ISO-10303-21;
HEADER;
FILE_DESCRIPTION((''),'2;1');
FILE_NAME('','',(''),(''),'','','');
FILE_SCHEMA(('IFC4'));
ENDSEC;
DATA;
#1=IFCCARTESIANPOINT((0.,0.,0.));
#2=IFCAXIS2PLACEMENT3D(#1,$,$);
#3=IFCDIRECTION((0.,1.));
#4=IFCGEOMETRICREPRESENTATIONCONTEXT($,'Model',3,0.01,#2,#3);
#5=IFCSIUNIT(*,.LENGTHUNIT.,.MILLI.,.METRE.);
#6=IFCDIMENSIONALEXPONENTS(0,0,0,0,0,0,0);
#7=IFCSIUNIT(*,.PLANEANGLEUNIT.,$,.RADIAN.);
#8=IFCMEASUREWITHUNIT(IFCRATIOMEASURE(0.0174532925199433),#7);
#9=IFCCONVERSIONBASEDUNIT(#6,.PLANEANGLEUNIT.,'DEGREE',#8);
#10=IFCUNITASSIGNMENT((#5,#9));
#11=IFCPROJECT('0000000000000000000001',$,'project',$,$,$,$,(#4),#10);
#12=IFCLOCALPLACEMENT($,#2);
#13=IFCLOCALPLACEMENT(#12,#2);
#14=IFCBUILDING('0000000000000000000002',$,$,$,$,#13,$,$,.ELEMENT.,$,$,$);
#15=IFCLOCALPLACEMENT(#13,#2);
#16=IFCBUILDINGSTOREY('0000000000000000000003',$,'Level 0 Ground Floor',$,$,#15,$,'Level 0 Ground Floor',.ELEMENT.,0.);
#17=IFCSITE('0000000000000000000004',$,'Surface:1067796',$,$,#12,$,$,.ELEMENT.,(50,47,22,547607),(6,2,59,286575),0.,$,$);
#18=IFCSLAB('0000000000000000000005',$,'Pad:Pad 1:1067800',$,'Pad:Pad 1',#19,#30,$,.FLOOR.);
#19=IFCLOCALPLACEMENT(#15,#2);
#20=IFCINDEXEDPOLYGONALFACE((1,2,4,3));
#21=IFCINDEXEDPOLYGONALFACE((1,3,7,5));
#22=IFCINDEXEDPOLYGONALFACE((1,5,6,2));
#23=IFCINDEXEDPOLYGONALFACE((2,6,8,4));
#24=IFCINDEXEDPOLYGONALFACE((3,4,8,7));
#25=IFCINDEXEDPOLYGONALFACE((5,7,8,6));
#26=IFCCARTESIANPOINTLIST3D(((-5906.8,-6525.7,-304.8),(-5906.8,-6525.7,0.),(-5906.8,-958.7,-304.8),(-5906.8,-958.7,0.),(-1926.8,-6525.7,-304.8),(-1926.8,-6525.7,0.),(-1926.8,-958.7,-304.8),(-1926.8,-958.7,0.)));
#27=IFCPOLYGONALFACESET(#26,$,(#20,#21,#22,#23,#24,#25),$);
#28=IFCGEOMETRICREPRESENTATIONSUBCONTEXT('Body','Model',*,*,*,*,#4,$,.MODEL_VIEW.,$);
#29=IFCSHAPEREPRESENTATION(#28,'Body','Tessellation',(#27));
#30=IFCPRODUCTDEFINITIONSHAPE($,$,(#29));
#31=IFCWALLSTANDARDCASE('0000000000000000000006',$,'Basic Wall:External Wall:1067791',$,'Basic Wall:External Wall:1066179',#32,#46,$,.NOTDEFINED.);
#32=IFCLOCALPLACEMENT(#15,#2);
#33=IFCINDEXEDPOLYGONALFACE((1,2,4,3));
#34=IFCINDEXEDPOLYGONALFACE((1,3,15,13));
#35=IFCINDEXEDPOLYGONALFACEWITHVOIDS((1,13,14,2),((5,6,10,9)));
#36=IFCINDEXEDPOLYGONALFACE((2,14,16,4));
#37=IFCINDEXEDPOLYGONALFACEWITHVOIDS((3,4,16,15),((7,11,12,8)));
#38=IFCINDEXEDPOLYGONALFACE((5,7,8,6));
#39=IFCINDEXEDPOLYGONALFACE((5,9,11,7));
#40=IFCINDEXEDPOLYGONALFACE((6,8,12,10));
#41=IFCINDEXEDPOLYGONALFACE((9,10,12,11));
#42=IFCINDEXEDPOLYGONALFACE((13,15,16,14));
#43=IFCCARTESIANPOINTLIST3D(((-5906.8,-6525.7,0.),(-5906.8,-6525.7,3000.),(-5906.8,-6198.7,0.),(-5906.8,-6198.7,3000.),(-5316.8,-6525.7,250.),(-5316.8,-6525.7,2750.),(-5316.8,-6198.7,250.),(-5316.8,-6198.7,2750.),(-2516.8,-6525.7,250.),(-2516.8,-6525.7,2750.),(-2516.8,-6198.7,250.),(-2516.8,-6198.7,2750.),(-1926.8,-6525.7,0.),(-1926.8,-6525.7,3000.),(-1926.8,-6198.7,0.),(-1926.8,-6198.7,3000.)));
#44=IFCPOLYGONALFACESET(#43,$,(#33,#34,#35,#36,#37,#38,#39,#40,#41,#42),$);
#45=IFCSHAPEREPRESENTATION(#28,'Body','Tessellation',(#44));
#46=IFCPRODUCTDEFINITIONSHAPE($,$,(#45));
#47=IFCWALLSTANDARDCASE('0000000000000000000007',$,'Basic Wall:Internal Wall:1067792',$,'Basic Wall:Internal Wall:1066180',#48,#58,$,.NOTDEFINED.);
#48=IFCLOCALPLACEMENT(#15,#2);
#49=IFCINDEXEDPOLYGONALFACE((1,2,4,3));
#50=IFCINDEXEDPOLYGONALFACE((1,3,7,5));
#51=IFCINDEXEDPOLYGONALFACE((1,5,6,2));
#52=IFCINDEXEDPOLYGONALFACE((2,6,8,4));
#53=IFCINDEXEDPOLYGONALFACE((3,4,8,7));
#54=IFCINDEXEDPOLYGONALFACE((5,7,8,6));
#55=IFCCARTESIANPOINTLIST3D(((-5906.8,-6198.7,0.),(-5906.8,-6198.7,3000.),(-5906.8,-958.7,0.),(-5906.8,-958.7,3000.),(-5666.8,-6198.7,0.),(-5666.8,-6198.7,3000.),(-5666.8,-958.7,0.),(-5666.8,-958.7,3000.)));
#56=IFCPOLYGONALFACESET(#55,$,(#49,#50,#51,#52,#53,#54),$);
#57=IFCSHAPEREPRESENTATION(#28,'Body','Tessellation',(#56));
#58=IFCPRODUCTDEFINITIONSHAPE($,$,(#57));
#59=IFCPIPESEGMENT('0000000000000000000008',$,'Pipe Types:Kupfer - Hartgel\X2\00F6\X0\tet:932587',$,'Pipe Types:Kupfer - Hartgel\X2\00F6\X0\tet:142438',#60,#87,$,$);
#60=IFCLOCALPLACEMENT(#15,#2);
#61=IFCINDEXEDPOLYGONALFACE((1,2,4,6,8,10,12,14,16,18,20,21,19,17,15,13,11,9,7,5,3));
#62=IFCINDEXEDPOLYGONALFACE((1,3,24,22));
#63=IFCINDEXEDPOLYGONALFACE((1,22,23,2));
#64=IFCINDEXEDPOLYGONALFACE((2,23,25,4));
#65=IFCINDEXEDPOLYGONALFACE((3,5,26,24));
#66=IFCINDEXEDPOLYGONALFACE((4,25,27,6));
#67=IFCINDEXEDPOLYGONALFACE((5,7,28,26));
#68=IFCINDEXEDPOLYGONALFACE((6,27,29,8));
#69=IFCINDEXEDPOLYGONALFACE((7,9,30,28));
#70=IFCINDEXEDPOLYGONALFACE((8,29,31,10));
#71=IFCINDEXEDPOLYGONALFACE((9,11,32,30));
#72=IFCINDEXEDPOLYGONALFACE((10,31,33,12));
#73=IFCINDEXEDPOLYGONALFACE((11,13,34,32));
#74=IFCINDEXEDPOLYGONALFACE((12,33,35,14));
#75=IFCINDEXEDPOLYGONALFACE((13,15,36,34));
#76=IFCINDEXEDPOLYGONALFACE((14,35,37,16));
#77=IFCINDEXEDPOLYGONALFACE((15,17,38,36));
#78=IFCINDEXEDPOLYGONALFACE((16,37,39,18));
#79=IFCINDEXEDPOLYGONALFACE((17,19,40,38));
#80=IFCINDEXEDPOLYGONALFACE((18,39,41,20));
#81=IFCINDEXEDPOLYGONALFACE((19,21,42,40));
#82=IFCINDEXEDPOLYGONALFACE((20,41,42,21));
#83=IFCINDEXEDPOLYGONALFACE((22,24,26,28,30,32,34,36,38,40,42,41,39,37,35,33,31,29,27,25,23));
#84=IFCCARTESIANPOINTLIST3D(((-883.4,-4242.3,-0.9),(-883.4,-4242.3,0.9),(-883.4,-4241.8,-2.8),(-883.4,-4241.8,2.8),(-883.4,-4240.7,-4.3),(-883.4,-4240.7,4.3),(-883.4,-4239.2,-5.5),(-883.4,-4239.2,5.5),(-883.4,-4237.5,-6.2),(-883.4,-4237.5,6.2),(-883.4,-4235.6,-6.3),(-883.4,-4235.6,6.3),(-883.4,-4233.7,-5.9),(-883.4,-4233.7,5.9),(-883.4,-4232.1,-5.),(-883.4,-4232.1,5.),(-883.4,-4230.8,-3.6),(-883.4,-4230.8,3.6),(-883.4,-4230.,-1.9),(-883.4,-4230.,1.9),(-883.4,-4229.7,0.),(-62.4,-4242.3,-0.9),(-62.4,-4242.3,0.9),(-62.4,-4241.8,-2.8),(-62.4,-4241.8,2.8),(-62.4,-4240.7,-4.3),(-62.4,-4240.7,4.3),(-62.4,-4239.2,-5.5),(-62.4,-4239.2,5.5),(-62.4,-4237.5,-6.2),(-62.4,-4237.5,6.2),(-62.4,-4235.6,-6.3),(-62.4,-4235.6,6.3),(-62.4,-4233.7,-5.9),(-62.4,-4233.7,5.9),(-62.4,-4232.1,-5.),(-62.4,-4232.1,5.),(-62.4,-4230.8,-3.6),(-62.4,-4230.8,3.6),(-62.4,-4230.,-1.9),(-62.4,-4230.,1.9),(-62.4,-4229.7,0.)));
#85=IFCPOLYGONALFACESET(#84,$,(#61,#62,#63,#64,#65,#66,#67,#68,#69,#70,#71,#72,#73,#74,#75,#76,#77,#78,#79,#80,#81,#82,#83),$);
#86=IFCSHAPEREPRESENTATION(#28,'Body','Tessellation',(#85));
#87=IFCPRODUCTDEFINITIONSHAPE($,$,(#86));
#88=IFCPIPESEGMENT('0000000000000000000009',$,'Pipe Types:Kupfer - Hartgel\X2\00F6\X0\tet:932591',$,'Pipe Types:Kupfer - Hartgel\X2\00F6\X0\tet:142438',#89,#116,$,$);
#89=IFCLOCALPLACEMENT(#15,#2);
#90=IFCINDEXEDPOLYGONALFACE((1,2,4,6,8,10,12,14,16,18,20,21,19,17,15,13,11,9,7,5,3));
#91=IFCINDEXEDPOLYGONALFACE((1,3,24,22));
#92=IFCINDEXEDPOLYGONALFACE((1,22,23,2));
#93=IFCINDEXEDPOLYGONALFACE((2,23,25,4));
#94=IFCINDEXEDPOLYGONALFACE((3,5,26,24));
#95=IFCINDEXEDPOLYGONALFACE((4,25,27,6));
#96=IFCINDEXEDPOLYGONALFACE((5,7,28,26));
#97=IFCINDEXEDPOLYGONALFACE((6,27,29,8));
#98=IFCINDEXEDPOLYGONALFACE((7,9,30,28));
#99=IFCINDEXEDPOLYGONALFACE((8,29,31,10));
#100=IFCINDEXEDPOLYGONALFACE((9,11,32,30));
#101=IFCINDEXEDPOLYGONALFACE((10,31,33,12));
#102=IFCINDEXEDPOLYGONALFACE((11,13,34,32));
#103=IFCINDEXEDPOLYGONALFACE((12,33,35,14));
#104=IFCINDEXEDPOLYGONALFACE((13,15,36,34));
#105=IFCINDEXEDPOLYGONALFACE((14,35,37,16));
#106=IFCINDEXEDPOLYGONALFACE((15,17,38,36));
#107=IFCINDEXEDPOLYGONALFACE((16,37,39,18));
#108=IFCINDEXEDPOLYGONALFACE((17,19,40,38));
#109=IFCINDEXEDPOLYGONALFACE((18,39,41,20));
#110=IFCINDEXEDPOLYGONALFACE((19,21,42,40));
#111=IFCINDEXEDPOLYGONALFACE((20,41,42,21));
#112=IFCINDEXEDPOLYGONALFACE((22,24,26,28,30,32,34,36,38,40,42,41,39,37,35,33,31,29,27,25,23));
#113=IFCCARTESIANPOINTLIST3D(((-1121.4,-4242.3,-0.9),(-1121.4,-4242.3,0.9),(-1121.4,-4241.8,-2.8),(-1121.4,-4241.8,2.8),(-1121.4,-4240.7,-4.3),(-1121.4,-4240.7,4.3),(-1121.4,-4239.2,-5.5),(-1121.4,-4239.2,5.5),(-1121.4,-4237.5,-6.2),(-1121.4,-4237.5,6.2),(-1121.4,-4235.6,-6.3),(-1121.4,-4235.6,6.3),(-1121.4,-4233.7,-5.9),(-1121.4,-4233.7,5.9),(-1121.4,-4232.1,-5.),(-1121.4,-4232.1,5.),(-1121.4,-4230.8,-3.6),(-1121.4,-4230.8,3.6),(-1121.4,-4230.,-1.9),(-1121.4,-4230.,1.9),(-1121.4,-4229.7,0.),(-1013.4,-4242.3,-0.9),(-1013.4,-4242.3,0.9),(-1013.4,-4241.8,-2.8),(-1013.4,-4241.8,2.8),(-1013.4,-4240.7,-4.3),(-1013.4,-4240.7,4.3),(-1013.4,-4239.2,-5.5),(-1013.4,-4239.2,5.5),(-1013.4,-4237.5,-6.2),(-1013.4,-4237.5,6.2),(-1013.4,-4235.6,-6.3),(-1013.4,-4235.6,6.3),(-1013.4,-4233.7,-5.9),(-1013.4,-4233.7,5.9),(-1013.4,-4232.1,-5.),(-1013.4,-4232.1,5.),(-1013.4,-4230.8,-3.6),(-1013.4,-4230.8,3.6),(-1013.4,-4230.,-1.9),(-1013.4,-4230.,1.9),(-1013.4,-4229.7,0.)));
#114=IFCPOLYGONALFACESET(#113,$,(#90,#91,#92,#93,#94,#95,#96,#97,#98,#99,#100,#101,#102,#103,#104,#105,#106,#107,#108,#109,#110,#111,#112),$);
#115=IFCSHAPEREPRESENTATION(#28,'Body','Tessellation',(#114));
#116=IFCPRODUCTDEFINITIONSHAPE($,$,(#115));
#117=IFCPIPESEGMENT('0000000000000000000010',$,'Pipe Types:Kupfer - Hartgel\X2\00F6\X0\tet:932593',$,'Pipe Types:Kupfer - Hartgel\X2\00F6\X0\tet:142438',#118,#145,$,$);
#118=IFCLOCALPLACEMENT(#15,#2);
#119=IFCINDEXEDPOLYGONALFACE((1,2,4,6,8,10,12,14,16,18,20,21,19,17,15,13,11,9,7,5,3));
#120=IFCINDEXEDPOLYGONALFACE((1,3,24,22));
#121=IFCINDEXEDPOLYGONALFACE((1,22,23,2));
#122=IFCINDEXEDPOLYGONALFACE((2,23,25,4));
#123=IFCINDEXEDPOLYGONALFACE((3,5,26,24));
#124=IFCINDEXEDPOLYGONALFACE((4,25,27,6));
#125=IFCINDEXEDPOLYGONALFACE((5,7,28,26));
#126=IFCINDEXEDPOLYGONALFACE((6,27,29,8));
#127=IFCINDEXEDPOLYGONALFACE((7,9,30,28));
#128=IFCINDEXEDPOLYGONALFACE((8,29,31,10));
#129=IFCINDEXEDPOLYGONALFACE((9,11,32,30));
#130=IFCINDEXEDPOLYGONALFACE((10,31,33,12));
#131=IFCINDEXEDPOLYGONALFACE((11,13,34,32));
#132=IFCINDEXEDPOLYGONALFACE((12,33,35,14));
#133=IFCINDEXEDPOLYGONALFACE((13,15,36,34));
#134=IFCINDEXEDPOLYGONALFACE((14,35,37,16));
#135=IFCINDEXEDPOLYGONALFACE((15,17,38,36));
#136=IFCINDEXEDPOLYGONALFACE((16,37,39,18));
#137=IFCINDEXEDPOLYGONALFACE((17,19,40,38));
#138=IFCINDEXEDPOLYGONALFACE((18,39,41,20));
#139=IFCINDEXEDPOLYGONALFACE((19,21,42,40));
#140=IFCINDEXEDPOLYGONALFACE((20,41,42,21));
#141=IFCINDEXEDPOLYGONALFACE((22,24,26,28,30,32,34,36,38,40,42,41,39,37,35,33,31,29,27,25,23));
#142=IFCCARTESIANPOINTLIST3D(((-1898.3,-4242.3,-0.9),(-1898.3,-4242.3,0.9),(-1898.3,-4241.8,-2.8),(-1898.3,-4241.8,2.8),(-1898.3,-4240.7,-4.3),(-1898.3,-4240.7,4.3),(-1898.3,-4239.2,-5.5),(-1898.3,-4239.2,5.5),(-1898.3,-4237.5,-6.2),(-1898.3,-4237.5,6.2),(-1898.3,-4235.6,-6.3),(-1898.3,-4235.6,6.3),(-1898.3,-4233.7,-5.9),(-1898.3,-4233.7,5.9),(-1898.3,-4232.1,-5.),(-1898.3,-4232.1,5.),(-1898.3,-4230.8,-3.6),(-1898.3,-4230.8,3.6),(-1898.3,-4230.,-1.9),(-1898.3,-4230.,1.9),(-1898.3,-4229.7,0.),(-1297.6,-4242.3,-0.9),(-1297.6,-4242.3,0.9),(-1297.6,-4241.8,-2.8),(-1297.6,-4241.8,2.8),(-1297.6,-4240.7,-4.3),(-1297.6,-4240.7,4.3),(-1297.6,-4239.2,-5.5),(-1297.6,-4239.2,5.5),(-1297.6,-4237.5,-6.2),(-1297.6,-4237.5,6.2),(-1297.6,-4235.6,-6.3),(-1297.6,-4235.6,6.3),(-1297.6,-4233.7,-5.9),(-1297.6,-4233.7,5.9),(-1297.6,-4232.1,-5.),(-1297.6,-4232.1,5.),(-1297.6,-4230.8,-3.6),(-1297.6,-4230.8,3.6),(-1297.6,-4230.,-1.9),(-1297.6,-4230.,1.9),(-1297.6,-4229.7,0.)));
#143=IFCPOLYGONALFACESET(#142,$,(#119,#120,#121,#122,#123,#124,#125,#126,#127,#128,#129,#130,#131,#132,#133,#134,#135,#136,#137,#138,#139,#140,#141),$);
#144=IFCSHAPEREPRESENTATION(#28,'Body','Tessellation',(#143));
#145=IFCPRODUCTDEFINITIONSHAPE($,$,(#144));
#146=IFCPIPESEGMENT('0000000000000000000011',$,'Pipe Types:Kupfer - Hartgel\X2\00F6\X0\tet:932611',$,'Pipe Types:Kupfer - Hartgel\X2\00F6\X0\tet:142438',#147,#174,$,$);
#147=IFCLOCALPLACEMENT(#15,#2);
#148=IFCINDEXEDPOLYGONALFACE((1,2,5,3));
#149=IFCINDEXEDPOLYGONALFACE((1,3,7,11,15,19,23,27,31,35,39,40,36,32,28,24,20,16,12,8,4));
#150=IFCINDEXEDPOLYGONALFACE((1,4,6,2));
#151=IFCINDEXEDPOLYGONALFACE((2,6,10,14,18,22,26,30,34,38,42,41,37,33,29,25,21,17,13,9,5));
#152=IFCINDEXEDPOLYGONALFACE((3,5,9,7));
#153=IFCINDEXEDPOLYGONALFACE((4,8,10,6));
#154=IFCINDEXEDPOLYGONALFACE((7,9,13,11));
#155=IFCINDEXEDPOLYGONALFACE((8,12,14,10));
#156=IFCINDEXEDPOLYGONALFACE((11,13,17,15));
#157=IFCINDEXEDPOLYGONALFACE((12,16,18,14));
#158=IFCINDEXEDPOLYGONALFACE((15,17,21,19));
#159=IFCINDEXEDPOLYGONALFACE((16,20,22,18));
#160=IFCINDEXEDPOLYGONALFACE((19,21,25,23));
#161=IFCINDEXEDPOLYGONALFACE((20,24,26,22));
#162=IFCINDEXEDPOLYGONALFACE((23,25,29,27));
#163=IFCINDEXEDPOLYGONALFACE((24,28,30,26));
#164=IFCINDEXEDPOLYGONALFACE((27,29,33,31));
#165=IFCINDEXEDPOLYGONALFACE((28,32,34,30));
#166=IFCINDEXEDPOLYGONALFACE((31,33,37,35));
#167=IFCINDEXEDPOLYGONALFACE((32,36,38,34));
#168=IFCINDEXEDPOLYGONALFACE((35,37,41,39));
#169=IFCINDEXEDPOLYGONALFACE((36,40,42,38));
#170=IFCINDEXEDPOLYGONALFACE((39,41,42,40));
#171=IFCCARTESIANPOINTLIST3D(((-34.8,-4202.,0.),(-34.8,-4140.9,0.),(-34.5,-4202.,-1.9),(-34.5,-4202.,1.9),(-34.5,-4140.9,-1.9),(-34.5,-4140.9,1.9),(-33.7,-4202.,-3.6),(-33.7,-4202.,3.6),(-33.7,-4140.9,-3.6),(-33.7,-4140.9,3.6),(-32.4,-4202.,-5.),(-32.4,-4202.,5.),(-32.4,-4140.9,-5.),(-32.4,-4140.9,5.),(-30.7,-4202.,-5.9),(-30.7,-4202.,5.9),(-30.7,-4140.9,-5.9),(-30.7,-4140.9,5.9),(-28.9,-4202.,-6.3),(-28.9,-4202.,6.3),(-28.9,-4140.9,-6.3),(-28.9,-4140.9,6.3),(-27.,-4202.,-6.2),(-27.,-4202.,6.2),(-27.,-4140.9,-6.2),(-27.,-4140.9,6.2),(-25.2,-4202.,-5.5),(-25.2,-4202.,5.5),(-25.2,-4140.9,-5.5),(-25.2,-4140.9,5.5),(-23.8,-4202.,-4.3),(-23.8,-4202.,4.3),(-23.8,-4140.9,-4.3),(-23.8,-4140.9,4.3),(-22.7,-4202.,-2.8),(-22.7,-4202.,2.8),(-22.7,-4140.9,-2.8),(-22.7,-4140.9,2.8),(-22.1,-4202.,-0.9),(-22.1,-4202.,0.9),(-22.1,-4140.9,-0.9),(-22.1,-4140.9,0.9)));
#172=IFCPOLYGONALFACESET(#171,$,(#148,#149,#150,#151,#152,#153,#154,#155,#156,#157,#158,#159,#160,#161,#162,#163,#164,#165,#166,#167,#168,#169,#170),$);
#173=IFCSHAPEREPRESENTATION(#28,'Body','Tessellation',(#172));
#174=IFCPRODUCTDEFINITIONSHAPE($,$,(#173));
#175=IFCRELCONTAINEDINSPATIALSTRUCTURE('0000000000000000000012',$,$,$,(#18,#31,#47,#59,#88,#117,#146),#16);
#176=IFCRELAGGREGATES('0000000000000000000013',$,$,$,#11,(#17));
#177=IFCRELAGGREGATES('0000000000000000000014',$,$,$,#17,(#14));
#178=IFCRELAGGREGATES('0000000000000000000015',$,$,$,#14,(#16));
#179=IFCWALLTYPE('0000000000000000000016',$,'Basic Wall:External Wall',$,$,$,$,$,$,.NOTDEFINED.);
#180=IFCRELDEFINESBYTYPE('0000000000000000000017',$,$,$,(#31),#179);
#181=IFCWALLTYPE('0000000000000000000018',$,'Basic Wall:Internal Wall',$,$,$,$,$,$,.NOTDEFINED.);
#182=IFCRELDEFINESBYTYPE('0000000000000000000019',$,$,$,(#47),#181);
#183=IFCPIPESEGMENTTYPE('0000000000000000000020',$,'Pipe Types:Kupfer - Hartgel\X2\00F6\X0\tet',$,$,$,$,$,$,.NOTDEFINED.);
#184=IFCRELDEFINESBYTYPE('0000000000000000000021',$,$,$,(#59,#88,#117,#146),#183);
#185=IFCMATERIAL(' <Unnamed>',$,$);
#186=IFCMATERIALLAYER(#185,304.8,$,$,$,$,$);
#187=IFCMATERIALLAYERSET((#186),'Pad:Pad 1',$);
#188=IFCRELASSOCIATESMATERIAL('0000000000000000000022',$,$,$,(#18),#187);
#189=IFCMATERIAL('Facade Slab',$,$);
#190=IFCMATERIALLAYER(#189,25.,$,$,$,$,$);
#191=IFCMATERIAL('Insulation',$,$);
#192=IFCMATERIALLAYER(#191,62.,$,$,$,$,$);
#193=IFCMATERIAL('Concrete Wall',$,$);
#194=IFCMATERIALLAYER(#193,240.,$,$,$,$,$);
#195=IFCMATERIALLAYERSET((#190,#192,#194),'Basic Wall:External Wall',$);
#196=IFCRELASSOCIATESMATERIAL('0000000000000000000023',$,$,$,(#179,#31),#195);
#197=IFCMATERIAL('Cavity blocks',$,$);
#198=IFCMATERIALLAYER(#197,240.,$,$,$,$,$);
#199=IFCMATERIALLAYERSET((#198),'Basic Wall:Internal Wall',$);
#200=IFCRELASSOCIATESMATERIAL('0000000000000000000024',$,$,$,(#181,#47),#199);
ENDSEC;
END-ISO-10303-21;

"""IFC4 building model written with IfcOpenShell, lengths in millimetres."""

from ifc_helpers import new_model, entity, si_unit, converted_unit, direction, frame, frame_2d, origin, place, context, subcontext, project, spatial, polyline, rectangle, circle, extrude, clip, bounded_halfspace, material, layer, layer_set, layer_usage, type_object, element, save


model = new_model("IFC4")

# Units and contexts
model_context = context("Model", 3, precision=0.01, world=origin(), true_north=direction((0.0, 1.0)))
body_context = subcontext(model_context, "Body", "Model", "MODEL_VIEW")
ifc_project = project(units=[si_unit("LENGTHUNIT", "METRE", prefix="MILLI"), converted_unit("PLANEANGLEUNIT", "DEGREE", entity("IfcRatioMeasure", 0.0174532925199433), si_unit("PLANEANGLEUNIT", "RADIAN"), dimensions=[0, 0, 0, 0, 0, 0, 0])], contexts=[model_context])

# Site, building, storey
site_placement = place(None, origin())
site = spatial("IfcSite", under=ifc_project, at=site_placement, Name="Surface:1067796", CompositionType="ELEMENT", RefLatitude=(50, 47, 22, 547607), RefLongitude=(6, 2, 59, 286575), RefElevation=0.0)
building_placement = place(site_placement, origin())
building = spatial("IfcBuilding", under=site, at=building_placement, CompositionType="ELEMENT")
storey_placement = place(building_placement, origin())
storey = spatial("IfcBuildingStorey", under=building, at=storey_placement, Name="Level 0 Ground Floor", LongName="Level 0 Ground Floor", CompositionType="ELEMENT", Elevation=0.0)

# Slab
ifc_material_1 = material(Name=" <Unnamed>")
ifc_layer_1 = layer(ifc_material_1, 304.8)
ifc_layer_set_1 = layer_set([ifc_layer_1], Name="Pad:Pad 1")
ifc_layer_usage_1 = layer_usage(ifc_layer_set_1, "AXIS3", "NEGATIVE", 0.0)
slab_placement = place(storey_placement, frame((-5906.8, -6525.7, -304.8)))
element("IfcSlab", 1, at=slab_placement, inside=storey, material=ifc_layer_usage_1, Name="Pad:Pad 1:1067800", ObjectType="Pad:Pad 1", PredefinedType="FLOOR", context=body_context, shape_type="SweptSolid", body=[
    extrude(rectangle(XDim=5567.0, YDim=3980.0, at=frame_2d((0.0, 0.0), x_axis=(0.0, -1.0))), frame((1990.0, 2783.5, 304.8), z_axis=(0.0, 0.0, -1.0), x_axis=(-1.0, 0.0, 0.0)), (0.0, 0.0, 1.0), 304.8),
])

# Wall, opening
ifc_material_2 = material(Name="Facade Slab")
ifc_layer_2 = layer(ifc_material_2, 25.0)
ifc_material_3 = material(Name="Insulation")
ifc_layer_3 = layer(ifc_material_3, 62.0)
ifc_material_4 = material(Name="Concrete Wall")
ifc_layer_4 = layer(ifc_material_4, 240.0)
ifc_layer_set_2 = layer_set([ifc_layer_2, ifc_layer_3, ifc_layer_4], Name="Basic Wall:External Wall")
ifc_layer_usage_2 = layer_usage(ifc_layer_set_2, "AXIS2", "POSITIVE", -163.5)
wall_type_1 = type_object("IfcWallType", Name="Basic Wall:External Wall", PredefinedType="NOTDEFINED", material=ifc_layer_set_2)
wall_1_placement = place(storey_placement, frame((-5906.8, -6362.2, 0.0)))
wall_1 = element("IfcWallStandardCase", 2, at=wall_1_placement, inside=storey, type_object=wall_type_1, material=ifc_layer_usage_2, Name="Basic Wall:External Wall:1067791", ObjectType="Basic Wall:External Wall:1066179", PredefinedType="NOTDEFINED", context=body_context, shape_type="Clipping", body=[
    clip(extrude(rectangle(XDim=3980.0, YDim=327.0, at=frame_2d((1990.0, 0.0), x_axis=(-1.0, 0.0))), origin(), (0.0, 0.0, 1.0), 3000.0), bounded_halfspace(frame((0.0, -163.5, 3000.0), z_axis=(0.0, 0.0, -1.0), x_axis=(0.0, -1.0, 0.0)), True, frame((0.0, -163.5, 3000.0)), polyline([(0.0, 0.0), (3980.0, 0.0), (3980.0, 327.0), (3740.0, 327.0), (240.0, 327.0), (0.0, 327.0), (0.0, 0.0)]))),
])
opening_placement = place(wall_1_placement, frame((590.0, -163.5, 250.0)))
element("IfcOpeningElement", 3, at=opening_placement, cuts=wall_1, ObjectType="Opening", PredefinedType="OPENING", context=body_context, shape_type="SweptSolid", body=[
    extrude(rectangle(XDim=2500.0, YDim=2800.0, at=frame_2d((1250.0, 1400.0), x_axis=(1.0, 0.0))), frame((0.0, 0.0, 0.0), z_axis=(0.0, 1.0, 0.0), x_axis=(0.0, 0.0, 1.0)), (0.0, 0.0, 1.0), 327.0),
])

# Wall
ifc_material_5 = material(Name="Cavity blocks")
ifc_layer_5 = layer(ifc_material_5, 240.0)
ifc_layer_set_3 = layer_set([ifc_layer_5], Name="Basic Wall:Internal Wall")
ifc_layer_usage_3 = layer_usage(ifc_layer_set_3, "AXIS2", "NEGATIVE", 120.0)
wall_type_2 = type_object("IfcWallType", Name="Basic Wall:Internal Wall", PredefinedType="NOTDEFINED", material=ifc_layer_set_3)
wall_2_placement = place(storey_placement, frame((-5786.8, -6198.7, 0.0), z_axis=(0.0, 0.0, 1.0), x_axis=(0.0, 1.0, 0.0)))
element("IfcWallStandardCase", 4, at=wall_2_placement, inside=storey, type_object=wall_type_2, material=ifc_layer_usage_3, Name="Basic Wall:Internal Wall:1067792", ObjectType="Basic Wall:Internal Wall:1066180", PredefinedType="NOTDEFINED", context=body_context, shape_type="Clipping", body=[
    clip(extrude(rectangle(XDim=5240.0, YDim=240.0, at=frame_2d((2620.0, 0.0), x_axis=(-1.0, 0.0))), origin(), (0.0, 0.0, 1.0), 3000.0), bounded_halfspace(frame((0.0, -120.0, 3000.0), z_axis=(0.0, 0.0, -1.0), x_axis=(-1.0, 0.0, 0.0)), True, frame((0.0, -120.0, 3000.0)), polyline([(0.0, 0.0), (5000.0, 0.0), (5240.0, 0.0), (5240.0, 240.0), (0.0, 240.0), (0.0, 0.0)]))),
])

# Pipe segments
pipe_segment_type_1 = type_object("IfcPipeSegmentType", Name="Pipe Types:Kupfer - Hartgelötet", PredefinedType="NOTDEFINED")
pipe_segment_1_placement = place(storey_placement, frame((-883.4, -4244.0, -7.9)))
element("IfcPipeSegment", 5, at=pipe_segment_1_placement, inside=storey, type_object=pipe_segment_type_1, Name="Pipe Types:Kupfer - Hartgelötet:932587", ObjectType="Pipe Types:Kupfer - Hartgelötet:142438", context=body_context, shape_type="SweptSolid", body=[
    extrude(circle(Radius=6.3, at=frame_2d((0.0, 0.0), x_axis=(1.0, 0.0))), frame((0.0, 7.9, 7.9), z_axis=(1.0, 0.0, 0.0), x_axis=(0.0, 1.0, 0.0)), (0.0, 0.0, 1.0), 821.0),
])
pipe_segment_2_placement = place(storey_placement, frame((-1121.4, -4244.0, -7.9)))
element("IfcPipeSegment", 6, at=pipe_segment_2_placement, inside=storey, type_object=pipe_segment_type_1, Name="Pipe Types:Kupfer - Hartgelötet:932591", ObjectType="Pipe Types:Kupfer - Hartgelötet:142438", context=body_context, shape_type="SweptSolid", body=[
    extrude(circle(Radius=6.3, at=frame_2d((0.0, 0.0), x_axis=(1.0, 0.0))), frame((0.0, 7.9, 7.9), z_axis=(1.0, 0.0, 0.0), x_axis=(0.0, 1.0, 0.0)), (0.0, 0.0, 1.0), 108.0),
])
pipe_segment_3_placement = place(storey_placement, frame((-1898.3, -4244.0, -7.9)))
element("IfcPipeSegment", 7, at=pipe_segment_3_placement, inside=storey, type_object=pipe_segment_type_1, Name="Pipe Types:Kupfer - Hartgelötet:932593", ObjectType="Pipe Types:Kupfer - Hartgelötet:142438", context=body_context, shape_type="SweptSolid", body=[
    extrude(circle(Radius=6.3, at=frame_2d((0.0, 0.0), x_axis=(1.0, 0.0))), frame((0.0, 7.9, 7.9), z_axis=(1.0, 0.0, 0.0), x_axis=(0.0, 1.0, 0.0)), (0.0, 0.0, 1.0), 600.7),
])
pipe_segment_4_placement = place(storey_placement, frame((-36.4, -4202.0, -7.9)))
element("IfcPipeSegment", 8, at=pipe_segment_4_placement, inside=storey, type_object=pipe_segment_type_1, Name="Pipe Types:Kupfer - Hartgelötet:932611", ObjectType="Pipe Types:Kupfer - Hartgelötet:142438", context=body_context, shape_type="SweptSolid", body=[
    extrude(circle(Radius=6.3, at=frame_2d((0.0, 0.0), x_axis=(1.0, 0.0))), frame((7.9, 0.0, 7.9), z_axis=(0.0, 1.0, 0.0), x_axis=(-1.0, 0.0, 0.0)), (0.0, 0.0, 1.0), 61.1),
])

save(model, "model.ifc")
